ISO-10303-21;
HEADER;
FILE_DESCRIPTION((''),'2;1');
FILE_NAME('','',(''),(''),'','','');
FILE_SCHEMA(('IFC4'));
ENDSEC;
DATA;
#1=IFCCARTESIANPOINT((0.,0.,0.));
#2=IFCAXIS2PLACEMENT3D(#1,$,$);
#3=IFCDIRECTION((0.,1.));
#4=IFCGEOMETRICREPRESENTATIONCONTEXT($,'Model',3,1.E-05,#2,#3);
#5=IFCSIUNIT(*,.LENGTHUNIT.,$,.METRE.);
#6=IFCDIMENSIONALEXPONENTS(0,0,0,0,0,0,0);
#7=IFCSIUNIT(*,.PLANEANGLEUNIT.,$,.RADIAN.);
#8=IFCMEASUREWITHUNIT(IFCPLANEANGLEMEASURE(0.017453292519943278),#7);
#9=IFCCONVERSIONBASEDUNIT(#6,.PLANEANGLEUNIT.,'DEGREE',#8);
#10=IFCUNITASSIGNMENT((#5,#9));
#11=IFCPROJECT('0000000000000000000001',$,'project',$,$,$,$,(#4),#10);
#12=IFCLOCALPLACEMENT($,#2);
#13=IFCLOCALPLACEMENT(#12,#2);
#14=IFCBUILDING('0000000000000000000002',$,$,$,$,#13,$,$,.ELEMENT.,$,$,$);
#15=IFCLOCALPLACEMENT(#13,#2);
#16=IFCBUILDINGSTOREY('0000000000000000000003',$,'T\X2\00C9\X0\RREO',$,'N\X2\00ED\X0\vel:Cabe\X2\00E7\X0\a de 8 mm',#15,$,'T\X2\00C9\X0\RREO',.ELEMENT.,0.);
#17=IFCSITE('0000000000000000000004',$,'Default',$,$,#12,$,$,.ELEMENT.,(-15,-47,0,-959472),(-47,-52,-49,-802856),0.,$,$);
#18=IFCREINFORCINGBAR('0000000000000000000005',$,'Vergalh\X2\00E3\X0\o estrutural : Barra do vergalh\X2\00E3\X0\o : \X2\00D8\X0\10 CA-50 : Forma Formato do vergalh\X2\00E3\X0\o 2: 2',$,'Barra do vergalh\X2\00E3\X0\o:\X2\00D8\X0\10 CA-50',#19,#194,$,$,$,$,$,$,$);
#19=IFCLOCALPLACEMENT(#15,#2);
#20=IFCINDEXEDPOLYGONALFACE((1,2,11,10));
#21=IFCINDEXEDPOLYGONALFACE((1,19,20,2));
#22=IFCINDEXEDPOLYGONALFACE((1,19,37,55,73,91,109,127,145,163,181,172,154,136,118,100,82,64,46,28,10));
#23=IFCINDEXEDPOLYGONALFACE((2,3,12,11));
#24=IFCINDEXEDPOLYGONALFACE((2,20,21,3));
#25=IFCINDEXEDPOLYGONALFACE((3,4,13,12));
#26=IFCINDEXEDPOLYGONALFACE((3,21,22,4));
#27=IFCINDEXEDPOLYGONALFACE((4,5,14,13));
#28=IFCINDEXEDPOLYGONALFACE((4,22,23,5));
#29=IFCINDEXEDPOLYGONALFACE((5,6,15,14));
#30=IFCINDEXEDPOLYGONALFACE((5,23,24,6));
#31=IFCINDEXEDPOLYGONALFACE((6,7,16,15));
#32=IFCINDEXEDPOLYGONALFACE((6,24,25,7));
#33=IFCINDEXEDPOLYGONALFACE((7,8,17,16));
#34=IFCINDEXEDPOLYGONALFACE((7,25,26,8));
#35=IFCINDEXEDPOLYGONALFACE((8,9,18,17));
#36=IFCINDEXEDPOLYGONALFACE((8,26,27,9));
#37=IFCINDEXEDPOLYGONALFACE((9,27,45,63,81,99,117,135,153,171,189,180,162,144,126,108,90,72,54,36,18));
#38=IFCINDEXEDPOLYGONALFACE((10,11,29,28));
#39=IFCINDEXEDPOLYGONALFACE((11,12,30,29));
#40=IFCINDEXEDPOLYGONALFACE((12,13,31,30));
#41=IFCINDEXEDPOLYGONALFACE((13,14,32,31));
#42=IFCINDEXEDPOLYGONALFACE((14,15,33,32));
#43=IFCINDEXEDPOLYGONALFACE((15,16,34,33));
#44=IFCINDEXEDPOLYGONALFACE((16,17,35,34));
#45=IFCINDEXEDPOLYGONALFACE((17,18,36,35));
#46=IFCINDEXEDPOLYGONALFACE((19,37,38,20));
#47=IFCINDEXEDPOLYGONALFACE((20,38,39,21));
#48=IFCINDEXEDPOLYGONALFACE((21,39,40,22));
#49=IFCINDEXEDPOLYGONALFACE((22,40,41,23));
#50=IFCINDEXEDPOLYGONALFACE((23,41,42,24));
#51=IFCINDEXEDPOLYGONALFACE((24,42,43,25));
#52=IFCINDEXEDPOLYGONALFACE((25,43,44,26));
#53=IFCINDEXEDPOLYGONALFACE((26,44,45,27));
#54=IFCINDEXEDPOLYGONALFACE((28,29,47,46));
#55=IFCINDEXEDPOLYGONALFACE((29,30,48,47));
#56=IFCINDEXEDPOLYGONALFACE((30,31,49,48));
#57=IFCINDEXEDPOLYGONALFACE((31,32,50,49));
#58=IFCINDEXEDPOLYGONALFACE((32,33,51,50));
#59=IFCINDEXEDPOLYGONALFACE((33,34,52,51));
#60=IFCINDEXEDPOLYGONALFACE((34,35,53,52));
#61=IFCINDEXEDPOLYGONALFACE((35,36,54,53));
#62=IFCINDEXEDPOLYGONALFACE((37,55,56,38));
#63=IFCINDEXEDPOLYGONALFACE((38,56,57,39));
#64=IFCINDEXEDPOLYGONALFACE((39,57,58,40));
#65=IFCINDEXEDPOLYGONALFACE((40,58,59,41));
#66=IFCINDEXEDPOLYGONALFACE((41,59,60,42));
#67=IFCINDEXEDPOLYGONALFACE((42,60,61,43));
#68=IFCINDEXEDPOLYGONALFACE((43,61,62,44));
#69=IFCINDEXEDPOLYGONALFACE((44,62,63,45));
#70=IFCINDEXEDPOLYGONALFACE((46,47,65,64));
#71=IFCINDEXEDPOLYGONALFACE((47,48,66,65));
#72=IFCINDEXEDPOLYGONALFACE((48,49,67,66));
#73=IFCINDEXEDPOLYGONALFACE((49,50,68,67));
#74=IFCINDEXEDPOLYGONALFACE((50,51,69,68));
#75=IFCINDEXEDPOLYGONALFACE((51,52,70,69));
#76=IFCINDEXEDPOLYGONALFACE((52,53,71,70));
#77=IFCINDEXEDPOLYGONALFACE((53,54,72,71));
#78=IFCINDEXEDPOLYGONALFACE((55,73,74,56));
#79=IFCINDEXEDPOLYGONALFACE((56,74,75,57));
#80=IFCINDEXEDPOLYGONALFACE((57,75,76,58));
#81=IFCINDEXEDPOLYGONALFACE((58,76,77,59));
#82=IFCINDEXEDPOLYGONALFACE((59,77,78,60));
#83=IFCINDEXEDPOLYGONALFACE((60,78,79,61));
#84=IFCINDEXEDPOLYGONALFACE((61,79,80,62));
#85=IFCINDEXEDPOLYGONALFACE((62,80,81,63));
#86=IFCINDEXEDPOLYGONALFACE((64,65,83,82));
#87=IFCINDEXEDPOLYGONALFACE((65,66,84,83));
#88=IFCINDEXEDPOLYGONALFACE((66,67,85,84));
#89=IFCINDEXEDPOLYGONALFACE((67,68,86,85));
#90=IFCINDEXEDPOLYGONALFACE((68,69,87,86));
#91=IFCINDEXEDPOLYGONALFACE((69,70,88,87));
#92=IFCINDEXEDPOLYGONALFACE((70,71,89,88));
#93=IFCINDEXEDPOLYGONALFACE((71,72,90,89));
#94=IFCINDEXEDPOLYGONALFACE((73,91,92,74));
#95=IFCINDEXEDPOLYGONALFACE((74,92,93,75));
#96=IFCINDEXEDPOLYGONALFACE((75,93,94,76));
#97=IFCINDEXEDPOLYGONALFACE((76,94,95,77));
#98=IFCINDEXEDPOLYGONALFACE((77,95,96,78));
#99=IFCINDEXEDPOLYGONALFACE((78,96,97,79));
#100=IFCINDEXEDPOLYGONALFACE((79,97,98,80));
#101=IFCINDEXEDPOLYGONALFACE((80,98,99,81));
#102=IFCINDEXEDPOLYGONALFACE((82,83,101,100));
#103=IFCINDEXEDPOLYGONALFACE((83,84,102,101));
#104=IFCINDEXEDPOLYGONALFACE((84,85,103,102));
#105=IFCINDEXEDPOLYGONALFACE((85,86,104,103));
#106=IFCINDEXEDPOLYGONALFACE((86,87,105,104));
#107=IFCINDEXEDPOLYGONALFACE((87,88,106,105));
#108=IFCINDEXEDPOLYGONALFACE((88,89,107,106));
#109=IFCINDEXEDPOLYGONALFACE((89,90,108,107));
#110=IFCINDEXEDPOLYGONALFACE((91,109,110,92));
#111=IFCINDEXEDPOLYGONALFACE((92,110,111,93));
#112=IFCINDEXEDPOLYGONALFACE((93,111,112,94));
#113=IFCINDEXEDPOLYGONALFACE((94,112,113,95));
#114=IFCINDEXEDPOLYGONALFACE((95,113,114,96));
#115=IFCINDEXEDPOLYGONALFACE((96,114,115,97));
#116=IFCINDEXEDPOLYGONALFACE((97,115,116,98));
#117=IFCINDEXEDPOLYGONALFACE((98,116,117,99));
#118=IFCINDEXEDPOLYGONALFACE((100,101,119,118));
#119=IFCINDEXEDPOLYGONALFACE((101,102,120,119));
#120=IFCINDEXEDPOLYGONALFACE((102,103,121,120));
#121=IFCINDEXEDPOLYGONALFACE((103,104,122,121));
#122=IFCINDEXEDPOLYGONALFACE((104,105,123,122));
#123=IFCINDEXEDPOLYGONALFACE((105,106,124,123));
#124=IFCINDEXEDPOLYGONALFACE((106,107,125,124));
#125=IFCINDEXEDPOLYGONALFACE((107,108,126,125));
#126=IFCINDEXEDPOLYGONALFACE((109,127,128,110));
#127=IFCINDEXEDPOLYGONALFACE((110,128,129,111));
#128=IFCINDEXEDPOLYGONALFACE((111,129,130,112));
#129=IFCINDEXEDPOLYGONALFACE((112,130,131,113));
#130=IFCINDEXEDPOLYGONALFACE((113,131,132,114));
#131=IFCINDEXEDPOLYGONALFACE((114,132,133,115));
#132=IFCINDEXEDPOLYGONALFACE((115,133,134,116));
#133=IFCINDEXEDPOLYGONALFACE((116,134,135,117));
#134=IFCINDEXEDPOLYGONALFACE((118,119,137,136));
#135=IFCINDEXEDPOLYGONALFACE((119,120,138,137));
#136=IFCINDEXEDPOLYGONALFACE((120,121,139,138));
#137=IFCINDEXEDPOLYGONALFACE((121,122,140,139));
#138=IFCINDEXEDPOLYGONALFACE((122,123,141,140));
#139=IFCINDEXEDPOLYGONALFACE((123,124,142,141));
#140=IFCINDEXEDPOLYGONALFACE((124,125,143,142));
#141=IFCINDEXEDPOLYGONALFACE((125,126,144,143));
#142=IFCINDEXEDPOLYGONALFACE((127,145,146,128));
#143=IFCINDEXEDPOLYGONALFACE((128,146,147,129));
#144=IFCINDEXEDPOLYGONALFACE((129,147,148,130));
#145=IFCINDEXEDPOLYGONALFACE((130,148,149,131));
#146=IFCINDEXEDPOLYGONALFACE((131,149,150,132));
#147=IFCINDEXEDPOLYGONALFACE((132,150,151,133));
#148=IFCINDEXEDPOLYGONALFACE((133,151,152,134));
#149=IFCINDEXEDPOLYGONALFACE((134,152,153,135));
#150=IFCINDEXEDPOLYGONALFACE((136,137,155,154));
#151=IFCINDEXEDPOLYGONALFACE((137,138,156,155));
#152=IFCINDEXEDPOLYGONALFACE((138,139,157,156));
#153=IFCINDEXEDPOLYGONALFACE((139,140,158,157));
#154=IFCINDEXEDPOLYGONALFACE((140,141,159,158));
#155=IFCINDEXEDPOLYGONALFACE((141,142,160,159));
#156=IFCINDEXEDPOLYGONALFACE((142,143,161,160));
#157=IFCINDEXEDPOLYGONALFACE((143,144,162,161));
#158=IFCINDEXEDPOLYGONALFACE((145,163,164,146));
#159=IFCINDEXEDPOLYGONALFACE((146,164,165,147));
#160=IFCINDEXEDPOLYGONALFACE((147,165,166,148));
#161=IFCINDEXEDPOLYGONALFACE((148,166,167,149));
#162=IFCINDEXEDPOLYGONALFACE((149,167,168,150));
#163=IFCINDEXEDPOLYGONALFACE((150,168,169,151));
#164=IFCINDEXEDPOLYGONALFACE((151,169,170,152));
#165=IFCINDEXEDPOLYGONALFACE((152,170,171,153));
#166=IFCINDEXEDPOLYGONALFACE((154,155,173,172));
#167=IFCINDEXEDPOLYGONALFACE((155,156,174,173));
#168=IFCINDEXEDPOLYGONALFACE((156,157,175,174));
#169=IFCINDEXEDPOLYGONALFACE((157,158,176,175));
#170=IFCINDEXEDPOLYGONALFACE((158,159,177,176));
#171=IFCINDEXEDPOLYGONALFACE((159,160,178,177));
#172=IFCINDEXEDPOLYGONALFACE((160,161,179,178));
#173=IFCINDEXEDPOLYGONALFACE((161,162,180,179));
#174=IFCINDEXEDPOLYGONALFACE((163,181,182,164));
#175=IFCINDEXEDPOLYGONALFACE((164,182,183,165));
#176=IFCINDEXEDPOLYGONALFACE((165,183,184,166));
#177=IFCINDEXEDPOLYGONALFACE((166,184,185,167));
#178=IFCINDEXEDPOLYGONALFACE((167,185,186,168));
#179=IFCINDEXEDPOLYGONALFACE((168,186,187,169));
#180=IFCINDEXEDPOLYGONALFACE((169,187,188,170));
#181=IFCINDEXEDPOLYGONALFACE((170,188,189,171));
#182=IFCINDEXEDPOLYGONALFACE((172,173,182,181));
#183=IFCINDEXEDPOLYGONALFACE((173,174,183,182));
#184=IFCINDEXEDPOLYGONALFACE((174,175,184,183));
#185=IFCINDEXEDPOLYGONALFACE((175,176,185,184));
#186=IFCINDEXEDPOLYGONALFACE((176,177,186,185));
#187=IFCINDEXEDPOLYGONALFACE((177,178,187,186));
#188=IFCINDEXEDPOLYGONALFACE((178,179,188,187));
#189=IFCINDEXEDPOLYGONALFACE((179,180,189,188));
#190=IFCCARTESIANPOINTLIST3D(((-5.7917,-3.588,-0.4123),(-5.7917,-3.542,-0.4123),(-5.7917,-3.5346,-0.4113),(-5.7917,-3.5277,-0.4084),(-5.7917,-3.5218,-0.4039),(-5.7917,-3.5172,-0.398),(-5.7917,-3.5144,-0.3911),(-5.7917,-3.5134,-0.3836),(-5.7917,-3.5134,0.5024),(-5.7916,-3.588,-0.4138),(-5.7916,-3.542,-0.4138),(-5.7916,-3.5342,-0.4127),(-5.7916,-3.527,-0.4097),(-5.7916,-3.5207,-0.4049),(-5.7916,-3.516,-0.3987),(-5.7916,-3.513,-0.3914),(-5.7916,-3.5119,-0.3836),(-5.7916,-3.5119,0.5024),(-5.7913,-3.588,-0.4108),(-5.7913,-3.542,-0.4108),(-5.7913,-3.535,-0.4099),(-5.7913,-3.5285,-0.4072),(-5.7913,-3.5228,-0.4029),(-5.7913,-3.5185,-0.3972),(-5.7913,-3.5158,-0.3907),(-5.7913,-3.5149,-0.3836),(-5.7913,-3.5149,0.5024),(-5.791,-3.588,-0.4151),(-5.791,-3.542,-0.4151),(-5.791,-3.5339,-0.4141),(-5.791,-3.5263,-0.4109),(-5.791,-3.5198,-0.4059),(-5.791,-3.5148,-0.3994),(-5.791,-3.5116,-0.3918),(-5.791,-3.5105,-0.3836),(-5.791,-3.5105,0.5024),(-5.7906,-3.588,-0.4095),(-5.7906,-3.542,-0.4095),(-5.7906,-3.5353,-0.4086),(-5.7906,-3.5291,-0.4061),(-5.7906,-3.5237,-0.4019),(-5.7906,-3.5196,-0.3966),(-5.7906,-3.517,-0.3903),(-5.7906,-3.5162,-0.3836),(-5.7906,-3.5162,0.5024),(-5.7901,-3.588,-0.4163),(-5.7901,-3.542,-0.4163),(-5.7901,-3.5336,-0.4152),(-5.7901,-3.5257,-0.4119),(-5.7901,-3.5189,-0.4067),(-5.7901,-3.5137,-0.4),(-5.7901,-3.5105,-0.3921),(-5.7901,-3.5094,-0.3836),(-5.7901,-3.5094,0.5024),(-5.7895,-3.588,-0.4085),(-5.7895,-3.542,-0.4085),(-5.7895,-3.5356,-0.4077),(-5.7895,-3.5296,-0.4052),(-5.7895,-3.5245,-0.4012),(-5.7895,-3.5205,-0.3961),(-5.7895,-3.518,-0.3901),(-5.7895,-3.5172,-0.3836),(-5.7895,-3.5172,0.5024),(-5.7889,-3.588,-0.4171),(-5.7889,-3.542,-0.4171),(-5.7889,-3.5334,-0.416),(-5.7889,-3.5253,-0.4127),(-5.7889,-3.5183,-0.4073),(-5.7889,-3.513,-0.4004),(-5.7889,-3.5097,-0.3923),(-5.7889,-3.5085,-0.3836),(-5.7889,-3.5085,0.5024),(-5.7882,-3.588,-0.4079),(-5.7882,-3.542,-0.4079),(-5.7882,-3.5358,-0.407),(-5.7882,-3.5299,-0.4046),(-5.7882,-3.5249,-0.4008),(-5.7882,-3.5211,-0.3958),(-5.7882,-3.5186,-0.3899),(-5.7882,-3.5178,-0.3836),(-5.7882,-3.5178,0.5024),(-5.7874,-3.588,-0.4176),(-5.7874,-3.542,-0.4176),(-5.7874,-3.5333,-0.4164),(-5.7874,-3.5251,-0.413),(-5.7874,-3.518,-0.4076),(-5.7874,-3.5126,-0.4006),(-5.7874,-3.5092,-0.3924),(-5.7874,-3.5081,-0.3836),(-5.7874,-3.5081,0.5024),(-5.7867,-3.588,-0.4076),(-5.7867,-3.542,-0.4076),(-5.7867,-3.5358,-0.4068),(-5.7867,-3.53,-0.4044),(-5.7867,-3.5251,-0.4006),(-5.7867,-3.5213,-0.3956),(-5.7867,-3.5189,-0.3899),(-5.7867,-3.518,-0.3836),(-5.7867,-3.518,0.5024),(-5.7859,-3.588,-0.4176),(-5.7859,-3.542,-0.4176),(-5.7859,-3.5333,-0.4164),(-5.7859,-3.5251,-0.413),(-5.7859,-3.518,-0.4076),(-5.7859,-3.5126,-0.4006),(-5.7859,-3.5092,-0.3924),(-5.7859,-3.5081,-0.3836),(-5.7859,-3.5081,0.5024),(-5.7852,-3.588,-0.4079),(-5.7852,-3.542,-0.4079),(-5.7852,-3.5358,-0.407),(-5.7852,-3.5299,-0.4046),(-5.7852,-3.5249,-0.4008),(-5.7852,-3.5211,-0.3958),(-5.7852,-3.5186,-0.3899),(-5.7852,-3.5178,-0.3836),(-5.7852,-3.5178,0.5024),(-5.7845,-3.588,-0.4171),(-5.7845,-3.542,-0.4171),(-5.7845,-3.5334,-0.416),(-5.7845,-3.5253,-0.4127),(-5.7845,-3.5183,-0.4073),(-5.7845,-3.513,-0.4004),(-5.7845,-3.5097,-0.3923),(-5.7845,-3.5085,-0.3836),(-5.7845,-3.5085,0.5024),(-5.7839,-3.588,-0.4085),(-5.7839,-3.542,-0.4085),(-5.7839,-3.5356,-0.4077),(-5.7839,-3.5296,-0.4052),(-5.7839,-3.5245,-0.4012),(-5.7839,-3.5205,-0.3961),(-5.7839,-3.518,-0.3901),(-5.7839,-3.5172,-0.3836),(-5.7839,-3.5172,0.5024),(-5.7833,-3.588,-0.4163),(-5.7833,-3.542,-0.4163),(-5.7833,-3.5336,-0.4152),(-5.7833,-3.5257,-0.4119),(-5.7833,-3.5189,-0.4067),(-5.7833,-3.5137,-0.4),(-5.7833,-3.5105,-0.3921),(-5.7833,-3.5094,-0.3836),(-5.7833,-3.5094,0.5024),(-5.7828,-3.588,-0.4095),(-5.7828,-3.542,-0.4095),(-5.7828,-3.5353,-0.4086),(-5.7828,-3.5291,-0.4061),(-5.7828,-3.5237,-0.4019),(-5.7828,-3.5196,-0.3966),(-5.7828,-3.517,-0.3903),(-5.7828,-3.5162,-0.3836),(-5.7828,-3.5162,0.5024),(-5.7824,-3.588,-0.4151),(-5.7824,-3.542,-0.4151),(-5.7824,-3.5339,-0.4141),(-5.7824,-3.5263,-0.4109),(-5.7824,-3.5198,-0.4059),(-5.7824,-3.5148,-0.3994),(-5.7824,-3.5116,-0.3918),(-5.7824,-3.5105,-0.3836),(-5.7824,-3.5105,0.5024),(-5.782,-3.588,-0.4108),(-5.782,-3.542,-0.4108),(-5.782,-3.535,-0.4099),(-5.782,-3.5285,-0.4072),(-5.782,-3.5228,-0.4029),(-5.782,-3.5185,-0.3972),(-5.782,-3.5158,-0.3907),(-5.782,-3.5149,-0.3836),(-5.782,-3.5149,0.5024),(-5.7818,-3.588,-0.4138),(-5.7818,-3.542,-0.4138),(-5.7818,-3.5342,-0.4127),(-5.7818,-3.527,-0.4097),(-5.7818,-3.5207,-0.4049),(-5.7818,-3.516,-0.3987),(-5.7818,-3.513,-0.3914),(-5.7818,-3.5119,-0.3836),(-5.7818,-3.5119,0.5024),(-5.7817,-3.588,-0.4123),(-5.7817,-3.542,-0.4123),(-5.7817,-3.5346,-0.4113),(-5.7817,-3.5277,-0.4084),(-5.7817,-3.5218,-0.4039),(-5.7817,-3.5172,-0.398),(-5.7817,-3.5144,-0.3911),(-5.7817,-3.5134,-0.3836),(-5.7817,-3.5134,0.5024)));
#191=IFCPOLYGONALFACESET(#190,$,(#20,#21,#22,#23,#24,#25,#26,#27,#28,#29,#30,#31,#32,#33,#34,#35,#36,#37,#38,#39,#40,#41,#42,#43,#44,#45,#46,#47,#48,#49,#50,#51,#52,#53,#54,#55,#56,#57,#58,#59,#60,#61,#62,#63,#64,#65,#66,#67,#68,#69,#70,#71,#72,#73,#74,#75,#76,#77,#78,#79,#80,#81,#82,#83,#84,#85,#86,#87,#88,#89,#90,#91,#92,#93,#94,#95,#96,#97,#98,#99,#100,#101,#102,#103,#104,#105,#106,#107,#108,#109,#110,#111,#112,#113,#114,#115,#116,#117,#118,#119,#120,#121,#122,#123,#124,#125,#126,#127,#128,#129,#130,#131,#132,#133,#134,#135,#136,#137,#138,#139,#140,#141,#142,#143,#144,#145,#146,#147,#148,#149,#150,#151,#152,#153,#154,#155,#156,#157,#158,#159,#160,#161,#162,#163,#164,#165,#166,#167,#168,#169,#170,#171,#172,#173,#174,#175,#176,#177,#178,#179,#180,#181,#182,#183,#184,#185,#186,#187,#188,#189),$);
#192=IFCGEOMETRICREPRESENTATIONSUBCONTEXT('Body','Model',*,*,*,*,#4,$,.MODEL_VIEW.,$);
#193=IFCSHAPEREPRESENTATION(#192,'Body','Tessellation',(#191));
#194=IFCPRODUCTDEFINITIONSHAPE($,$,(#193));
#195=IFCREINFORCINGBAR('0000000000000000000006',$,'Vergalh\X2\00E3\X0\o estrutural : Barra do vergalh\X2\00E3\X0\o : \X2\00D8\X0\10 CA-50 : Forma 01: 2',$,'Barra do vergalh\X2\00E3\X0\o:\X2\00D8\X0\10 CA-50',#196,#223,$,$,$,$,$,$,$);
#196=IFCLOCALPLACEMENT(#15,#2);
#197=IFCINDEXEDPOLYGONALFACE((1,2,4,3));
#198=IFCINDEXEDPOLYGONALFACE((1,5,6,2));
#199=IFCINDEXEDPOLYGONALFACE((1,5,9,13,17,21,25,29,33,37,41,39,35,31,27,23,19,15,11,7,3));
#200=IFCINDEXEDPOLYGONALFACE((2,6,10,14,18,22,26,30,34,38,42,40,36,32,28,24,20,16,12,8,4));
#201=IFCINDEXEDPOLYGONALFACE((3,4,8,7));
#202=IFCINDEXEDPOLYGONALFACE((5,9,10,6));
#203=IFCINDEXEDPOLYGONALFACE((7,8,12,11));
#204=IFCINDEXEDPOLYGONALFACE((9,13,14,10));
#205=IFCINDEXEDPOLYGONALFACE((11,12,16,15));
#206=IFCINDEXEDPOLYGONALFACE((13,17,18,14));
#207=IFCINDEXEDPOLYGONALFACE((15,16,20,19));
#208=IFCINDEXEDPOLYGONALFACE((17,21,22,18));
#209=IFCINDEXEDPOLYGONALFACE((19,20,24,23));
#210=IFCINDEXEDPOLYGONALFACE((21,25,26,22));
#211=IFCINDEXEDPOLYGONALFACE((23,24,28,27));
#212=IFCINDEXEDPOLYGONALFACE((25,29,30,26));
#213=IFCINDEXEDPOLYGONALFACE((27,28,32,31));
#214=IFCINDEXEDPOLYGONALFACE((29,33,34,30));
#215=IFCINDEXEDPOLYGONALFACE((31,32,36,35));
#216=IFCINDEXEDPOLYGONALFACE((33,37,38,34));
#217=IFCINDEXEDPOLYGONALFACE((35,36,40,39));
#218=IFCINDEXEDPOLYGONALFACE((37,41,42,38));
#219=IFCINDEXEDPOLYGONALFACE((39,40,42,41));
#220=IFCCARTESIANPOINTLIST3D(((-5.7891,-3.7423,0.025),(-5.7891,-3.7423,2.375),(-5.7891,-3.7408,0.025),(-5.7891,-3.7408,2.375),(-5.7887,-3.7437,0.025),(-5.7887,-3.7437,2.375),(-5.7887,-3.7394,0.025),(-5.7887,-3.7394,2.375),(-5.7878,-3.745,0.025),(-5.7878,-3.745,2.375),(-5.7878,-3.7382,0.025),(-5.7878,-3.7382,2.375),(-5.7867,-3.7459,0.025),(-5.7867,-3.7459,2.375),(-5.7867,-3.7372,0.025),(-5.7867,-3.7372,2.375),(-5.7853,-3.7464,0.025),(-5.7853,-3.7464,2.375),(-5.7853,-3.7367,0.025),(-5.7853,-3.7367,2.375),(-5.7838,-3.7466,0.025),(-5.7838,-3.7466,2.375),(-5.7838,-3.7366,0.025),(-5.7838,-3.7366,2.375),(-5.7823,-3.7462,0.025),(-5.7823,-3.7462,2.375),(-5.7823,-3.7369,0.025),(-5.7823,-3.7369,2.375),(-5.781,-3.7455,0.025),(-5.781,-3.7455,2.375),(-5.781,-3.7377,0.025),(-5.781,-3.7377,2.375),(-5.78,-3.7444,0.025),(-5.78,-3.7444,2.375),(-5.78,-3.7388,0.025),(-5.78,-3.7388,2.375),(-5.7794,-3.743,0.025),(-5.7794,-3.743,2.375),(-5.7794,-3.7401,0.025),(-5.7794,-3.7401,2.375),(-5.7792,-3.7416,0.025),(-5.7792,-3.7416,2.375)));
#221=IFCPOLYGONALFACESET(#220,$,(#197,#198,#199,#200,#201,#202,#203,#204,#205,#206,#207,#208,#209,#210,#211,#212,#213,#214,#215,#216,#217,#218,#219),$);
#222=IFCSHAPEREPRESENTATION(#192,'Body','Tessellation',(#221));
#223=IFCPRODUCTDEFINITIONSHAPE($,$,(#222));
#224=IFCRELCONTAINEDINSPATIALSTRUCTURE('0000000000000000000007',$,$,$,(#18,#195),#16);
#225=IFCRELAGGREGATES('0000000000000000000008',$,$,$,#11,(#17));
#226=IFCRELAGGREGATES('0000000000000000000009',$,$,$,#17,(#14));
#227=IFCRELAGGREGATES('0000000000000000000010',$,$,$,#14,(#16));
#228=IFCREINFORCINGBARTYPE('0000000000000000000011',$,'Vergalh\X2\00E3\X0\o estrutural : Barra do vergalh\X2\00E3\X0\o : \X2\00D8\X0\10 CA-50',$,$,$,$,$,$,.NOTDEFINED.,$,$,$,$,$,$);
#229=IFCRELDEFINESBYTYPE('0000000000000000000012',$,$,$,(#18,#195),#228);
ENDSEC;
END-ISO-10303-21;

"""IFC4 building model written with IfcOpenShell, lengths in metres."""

from ifc_helpers import new_model, entity, si_unit, converted_unit, direction, origin, place, context, subcontext, project, spatial, type_object, element, save


model = new_model("IFC4")

# Units and contexts
model_context = context("Model", 3, precision=1e-05, world=origin(), true_north=direction((0.0, 1.0)))
body_context = subcontext(model_context, "Body", "Model", "MODEL_VIEW")
ifc_project = project(units=[si_unit("LENGTHUNIT", "METRE"), converted_unit("PLANEANGLEUNIT", "DEGREE", entity("IfcPlaneAngleMeasure", 0.017453292519943278), si_unit("PLANEANGLEUNIT", "RADIAN"), dimensions=[0, 0, 0, 0, 0, 0, 0])], contexts=[model_context])

# Site, building, storey
site_placement = place(None, origin())
site = spatial("IfcSite", under=ifc_project, at=site_placement, Name="Default", CompositionType="ELEMENT", RefLatitude=(-15, -47, 0, -959472), RefLongitude=(-47, -52, -49, -802856), RefElevation=0.0)
building_placement = place(site_placement, origin())
building = spatial("IfcBuilding", under=site, at=building_placement, CompositionType="ELEMENT")
storey_placement = place(building_placement, origin())
storey = spatial("IfcBuildingStorey", under=building, at=storey_placement, Name="TÉRREO", ObjectType="Nível:Cabeça de 8 mm", LongName="TÉRREO", CompositionType="ELEMENT", Elevation=0.0)

# Reinforcing bars
reinforcing_bar_type_1 = type_object("IfcReinforcingBarType", Name="Vergalhão estrutural : Barra do vergalhão : Ø10 CA-50", PredefinedType="NOTDEFINED")
reinforcing_bar_1_placement = place(storey_placement, origin())
element("IfcReinforcingBar", 1, at=reinforcing_bar_1_placement, inside=storey, type_object=reinforcing_bar_type_1, Name="Vergalhão estrutural : Barra do vergalhão : Ø10 CA-50 : Forma Formato do vergalhão 2: 2", ObjectType="Barra do vergalhão:Ø10 CA-50", context=body_context, shape_type="AdvancedSweptSolid", body=[
    entity("IfcSweptDiskSolid", entity("IfcIndexedPolyCurve", entity("IfcCartesianPointList3D", [[-5.7867, -3.588, -0.4126], [-5.7867, -3.542, -0.4126], [-5.7867, -3.5215, -0.4042], [-5.7867, -3.513, -0.3836], [-5.7867, -3.513, 0.5024]]), [entity("IfcLineIndex", [1, 2]), entity("IfcArcIndex", [2, 3, 4]), entity("IfcLineIndex", [4, 5])], False), 0.005, None, 0.0, 92.0),
])
reinforcing_bar_2_placement = place(storey_placement, origin())
element("IfcReinforcingBar", 2, at=reinforcing_bar_2_placement, inside=storey, type_object=reinforcing_bar_type_1, Name="Vergalhão estrutural : Barra do vergalhão : Ø10 CA-50 : Forma 01: 2", ObjectType="Barra do vergalhão:Ø10 CA-50", context=body_context, shape_type="AdvancedSweptSolid", body=[
    entity("IfcSweptDiskSolid", entity("IfcIndexedPolyCurve", entity("IfcCartesianPointList3D", [[-5.7842, -3.7416, 0.025], [-5.7842, -3.7416, 2.375]]), None, False), 0.005, None, 0.0, 1.0),
])

save(model, "model.ifc")
